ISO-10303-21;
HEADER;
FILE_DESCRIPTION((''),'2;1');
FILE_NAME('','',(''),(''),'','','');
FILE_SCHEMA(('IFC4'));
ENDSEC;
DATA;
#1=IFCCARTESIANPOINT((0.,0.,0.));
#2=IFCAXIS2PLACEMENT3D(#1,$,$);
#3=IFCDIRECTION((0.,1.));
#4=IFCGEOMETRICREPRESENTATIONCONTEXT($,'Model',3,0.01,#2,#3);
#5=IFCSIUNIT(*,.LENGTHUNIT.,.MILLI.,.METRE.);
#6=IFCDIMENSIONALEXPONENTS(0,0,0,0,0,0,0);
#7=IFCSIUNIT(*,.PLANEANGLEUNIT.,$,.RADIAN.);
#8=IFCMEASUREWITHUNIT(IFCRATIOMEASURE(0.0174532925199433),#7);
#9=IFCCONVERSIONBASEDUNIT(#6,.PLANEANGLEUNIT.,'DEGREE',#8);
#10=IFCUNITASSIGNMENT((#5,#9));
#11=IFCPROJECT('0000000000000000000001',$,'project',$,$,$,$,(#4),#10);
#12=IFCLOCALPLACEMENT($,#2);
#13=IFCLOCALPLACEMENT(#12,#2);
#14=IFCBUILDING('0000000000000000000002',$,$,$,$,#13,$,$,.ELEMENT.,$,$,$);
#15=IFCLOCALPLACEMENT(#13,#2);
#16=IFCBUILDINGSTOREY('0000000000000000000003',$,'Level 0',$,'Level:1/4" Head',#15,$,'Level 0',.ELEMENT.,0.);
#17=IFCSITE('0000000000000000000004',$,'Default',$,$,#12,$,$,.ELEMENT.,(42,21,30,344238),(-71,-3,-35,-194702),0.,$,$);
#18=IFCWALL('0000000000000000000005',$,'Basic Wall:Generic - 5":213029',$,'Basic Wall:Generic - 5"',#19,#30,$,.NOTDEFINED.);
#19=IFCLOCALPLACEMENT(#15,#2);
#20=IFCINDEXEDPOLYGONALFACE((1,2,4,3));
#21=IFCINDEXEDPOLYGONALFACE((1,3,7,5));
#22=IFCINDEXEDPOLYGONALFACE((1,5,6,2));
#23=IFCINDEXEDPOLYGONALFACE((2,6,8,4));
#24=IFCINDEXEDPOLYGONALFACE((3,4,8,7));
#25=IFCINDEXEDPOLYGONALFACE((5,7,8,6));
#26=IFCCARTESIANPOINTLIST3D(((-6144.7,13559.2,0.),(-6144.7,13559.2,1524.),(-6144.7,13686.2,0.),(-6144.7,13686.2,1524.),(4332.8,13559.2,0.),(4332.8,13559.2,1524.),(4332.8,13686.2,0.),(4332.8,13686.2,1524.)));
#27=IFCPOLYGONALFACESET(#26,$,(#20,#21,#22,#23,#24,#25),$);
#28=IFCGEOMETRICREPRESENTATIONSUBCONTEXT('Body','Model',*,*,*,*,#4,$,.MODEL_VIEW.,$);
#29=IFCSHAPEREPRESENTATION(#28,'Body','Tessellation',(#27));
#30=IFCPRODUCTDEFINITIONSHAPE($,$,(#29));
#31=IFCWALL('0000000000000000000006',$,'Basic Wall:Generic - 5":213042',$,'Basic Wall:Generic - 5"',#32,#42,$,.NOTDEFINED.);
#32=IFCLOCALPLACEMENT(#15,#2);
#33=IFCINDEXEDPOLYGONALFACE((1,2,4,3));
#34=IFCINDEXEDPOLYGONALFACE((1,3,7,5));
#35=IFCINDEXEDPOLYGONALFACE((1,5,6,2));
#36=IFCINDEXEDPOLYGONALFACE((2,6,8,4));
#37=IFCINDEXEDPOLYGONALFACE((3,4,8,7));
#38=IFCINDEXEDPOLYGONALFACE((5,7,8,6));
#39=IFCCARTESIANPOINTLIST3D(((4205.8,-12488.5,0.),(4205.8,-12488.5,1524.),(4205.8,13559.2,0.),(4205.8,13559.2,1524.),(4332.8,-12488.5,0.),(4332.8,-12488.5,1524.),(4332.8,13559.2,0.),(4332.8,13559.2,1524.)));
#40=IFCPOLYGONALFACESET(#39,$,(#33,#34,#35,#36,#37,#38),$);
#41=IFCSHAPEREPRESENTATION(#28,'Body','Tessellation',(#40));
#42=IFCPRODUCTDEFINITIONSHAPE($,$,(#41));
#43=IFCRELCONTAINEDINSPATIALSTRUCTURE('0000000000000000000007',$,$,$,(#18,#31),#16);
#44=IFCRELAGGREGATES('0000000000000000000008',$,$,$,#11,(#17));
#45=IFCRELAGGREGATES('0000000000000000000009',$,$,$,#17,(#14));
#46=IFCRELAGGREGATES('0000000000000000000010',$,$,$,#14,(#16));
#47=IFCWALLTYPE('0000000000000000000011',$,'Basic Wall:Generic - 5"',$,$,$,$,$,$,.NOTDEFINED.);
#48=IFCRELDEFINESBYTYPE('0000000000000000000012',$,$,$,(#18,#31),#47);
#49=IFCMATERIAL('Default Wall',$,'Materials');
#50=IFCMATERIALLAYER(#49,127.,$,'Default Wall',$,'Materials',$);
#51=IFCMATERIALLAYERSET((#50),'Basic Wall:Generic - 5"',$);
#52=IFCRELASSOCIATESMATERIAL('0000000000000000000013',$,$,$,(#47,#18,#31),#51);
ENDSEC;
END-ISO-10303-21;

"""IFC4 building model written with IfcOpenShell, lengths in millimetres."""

from ifc_helpers import new_model, entity, si_unit, converted_unit, direction, frame, origin, place, context, subcontext, project, spatial, indexed_curve, outline, extrude, material, layer, layer_set, type_object, element, save


model = new_model("IFC4")

# Units and contexts
model_context = context("Model", 3, precision=0.01, world=origin(), true_north=direction((0.0, 1.0)))
body_context = subcontext(model_context, "Body", "Model", "MODEL_VIEW")
ifc_project = project(units=[si_unit("LENGTHUNIT", "METRE", prefix="MILLI"), converted_unit("PLANEANGLEUNIT", "DEGREE", entity("IfcRatioMeasure", 0.0174532925199433), si_unit("PLANEANGLEUNIT", "RADIAN"), dimensions=[0, 0, 0, 0, 0, 0, 0])], contexts=[model_context])

# Site, building, storey
site_placement = place(None, origin())
site = spatial("IfcSite", under=ifc_project, at=site_placement, Name="Default", CompositionType="ELEMENT", RefLatitude=(42, 21, 30, 344238), RefLongitude=(-71, -3, -35, -194702), RefElevation=0.0)
building_placement = place(site_placement, origin())
building = spatial("IfcBuilding", under=site, at=building_placement, CompositionType="ELEMENT")
storey_placement = place(building_placement, origin())
storey = spatial("IfcBuildingStorey", under=building, at=storey_placement, Name="Level 0", ObjectType="Level:1/4\" Head", LongName="Level 0", CompositionType="ELEMENT", Elevation=0.0)

# Walls
ifc_material = material(Name="Default Wall", Category="Materials")
ifc_layer = layer(ifc_material, 127.0, Name="Default Wall", Category="Materials")
ifc_layer_set = layer_set([ifc_layer], Name="Basic Wall:Generic - 5\"")
wall_type = type_object("IfcWallType", Name="Basic Wall:Generic - 5\"", PredefinedType="NOTDEFINED", material=ifc_layer_set)
wall_1_placement = place(storey_placement, frame((4332.8, 13622.7, 0.0), z_axis=(0.0, 0.0, 1.0), x_axis=(-1.0, 0.0, 0.0)))
element("IfcWall", 1, at=wall_1_placement, inside=storey, type_object=wall_type, material=ifc_layer_set, Name="Basic Wall:Generic - 5\":213029", ObjectType="Basic Wall:Generic - 5\"", PredefinedType="NOTDEFINED", context=body_context, shape_type="SweptSolid", body=[
    extrude(outline(indexed_curve([(10477.5, 63.5), (0.0, 63.5), (0.0, -63.5), (10477.5, -63.5), (10477.5, 63.5)], self_intersect=False)), origin(), (0.0, 0.0, 1.0), 1524.0),
])
wall_2_placement = place(storey_placement, frame((4269.3, -12488.5, 0.0), z_axis=(0.0, 0.0, 1.0), x_axis=(0.0, 1.0, 0.0)))
element("IfcWall", 2, at=wall_2_placement, inside=storey, type_object=wall_type, material=ifc_layer_set, Name="Basic Wall:Generic - 5\":213042", ObjectType="Basic Wall:Generic - 5\"", PredefinedType="NOTDEFINED", context=body_context, shape_type="SweptSolid", body=[
    extrude(outline(indexed_curve([(26047.7, 63.5), (0.0, 63.5), (0.0, -63.5), (26047.7, -63.5), (26047.7, 63.5)], self_intersect=False)), origin(), (0.0, 0.0, 1.0), 1524.0),
])

save(model, "model.ifc")
